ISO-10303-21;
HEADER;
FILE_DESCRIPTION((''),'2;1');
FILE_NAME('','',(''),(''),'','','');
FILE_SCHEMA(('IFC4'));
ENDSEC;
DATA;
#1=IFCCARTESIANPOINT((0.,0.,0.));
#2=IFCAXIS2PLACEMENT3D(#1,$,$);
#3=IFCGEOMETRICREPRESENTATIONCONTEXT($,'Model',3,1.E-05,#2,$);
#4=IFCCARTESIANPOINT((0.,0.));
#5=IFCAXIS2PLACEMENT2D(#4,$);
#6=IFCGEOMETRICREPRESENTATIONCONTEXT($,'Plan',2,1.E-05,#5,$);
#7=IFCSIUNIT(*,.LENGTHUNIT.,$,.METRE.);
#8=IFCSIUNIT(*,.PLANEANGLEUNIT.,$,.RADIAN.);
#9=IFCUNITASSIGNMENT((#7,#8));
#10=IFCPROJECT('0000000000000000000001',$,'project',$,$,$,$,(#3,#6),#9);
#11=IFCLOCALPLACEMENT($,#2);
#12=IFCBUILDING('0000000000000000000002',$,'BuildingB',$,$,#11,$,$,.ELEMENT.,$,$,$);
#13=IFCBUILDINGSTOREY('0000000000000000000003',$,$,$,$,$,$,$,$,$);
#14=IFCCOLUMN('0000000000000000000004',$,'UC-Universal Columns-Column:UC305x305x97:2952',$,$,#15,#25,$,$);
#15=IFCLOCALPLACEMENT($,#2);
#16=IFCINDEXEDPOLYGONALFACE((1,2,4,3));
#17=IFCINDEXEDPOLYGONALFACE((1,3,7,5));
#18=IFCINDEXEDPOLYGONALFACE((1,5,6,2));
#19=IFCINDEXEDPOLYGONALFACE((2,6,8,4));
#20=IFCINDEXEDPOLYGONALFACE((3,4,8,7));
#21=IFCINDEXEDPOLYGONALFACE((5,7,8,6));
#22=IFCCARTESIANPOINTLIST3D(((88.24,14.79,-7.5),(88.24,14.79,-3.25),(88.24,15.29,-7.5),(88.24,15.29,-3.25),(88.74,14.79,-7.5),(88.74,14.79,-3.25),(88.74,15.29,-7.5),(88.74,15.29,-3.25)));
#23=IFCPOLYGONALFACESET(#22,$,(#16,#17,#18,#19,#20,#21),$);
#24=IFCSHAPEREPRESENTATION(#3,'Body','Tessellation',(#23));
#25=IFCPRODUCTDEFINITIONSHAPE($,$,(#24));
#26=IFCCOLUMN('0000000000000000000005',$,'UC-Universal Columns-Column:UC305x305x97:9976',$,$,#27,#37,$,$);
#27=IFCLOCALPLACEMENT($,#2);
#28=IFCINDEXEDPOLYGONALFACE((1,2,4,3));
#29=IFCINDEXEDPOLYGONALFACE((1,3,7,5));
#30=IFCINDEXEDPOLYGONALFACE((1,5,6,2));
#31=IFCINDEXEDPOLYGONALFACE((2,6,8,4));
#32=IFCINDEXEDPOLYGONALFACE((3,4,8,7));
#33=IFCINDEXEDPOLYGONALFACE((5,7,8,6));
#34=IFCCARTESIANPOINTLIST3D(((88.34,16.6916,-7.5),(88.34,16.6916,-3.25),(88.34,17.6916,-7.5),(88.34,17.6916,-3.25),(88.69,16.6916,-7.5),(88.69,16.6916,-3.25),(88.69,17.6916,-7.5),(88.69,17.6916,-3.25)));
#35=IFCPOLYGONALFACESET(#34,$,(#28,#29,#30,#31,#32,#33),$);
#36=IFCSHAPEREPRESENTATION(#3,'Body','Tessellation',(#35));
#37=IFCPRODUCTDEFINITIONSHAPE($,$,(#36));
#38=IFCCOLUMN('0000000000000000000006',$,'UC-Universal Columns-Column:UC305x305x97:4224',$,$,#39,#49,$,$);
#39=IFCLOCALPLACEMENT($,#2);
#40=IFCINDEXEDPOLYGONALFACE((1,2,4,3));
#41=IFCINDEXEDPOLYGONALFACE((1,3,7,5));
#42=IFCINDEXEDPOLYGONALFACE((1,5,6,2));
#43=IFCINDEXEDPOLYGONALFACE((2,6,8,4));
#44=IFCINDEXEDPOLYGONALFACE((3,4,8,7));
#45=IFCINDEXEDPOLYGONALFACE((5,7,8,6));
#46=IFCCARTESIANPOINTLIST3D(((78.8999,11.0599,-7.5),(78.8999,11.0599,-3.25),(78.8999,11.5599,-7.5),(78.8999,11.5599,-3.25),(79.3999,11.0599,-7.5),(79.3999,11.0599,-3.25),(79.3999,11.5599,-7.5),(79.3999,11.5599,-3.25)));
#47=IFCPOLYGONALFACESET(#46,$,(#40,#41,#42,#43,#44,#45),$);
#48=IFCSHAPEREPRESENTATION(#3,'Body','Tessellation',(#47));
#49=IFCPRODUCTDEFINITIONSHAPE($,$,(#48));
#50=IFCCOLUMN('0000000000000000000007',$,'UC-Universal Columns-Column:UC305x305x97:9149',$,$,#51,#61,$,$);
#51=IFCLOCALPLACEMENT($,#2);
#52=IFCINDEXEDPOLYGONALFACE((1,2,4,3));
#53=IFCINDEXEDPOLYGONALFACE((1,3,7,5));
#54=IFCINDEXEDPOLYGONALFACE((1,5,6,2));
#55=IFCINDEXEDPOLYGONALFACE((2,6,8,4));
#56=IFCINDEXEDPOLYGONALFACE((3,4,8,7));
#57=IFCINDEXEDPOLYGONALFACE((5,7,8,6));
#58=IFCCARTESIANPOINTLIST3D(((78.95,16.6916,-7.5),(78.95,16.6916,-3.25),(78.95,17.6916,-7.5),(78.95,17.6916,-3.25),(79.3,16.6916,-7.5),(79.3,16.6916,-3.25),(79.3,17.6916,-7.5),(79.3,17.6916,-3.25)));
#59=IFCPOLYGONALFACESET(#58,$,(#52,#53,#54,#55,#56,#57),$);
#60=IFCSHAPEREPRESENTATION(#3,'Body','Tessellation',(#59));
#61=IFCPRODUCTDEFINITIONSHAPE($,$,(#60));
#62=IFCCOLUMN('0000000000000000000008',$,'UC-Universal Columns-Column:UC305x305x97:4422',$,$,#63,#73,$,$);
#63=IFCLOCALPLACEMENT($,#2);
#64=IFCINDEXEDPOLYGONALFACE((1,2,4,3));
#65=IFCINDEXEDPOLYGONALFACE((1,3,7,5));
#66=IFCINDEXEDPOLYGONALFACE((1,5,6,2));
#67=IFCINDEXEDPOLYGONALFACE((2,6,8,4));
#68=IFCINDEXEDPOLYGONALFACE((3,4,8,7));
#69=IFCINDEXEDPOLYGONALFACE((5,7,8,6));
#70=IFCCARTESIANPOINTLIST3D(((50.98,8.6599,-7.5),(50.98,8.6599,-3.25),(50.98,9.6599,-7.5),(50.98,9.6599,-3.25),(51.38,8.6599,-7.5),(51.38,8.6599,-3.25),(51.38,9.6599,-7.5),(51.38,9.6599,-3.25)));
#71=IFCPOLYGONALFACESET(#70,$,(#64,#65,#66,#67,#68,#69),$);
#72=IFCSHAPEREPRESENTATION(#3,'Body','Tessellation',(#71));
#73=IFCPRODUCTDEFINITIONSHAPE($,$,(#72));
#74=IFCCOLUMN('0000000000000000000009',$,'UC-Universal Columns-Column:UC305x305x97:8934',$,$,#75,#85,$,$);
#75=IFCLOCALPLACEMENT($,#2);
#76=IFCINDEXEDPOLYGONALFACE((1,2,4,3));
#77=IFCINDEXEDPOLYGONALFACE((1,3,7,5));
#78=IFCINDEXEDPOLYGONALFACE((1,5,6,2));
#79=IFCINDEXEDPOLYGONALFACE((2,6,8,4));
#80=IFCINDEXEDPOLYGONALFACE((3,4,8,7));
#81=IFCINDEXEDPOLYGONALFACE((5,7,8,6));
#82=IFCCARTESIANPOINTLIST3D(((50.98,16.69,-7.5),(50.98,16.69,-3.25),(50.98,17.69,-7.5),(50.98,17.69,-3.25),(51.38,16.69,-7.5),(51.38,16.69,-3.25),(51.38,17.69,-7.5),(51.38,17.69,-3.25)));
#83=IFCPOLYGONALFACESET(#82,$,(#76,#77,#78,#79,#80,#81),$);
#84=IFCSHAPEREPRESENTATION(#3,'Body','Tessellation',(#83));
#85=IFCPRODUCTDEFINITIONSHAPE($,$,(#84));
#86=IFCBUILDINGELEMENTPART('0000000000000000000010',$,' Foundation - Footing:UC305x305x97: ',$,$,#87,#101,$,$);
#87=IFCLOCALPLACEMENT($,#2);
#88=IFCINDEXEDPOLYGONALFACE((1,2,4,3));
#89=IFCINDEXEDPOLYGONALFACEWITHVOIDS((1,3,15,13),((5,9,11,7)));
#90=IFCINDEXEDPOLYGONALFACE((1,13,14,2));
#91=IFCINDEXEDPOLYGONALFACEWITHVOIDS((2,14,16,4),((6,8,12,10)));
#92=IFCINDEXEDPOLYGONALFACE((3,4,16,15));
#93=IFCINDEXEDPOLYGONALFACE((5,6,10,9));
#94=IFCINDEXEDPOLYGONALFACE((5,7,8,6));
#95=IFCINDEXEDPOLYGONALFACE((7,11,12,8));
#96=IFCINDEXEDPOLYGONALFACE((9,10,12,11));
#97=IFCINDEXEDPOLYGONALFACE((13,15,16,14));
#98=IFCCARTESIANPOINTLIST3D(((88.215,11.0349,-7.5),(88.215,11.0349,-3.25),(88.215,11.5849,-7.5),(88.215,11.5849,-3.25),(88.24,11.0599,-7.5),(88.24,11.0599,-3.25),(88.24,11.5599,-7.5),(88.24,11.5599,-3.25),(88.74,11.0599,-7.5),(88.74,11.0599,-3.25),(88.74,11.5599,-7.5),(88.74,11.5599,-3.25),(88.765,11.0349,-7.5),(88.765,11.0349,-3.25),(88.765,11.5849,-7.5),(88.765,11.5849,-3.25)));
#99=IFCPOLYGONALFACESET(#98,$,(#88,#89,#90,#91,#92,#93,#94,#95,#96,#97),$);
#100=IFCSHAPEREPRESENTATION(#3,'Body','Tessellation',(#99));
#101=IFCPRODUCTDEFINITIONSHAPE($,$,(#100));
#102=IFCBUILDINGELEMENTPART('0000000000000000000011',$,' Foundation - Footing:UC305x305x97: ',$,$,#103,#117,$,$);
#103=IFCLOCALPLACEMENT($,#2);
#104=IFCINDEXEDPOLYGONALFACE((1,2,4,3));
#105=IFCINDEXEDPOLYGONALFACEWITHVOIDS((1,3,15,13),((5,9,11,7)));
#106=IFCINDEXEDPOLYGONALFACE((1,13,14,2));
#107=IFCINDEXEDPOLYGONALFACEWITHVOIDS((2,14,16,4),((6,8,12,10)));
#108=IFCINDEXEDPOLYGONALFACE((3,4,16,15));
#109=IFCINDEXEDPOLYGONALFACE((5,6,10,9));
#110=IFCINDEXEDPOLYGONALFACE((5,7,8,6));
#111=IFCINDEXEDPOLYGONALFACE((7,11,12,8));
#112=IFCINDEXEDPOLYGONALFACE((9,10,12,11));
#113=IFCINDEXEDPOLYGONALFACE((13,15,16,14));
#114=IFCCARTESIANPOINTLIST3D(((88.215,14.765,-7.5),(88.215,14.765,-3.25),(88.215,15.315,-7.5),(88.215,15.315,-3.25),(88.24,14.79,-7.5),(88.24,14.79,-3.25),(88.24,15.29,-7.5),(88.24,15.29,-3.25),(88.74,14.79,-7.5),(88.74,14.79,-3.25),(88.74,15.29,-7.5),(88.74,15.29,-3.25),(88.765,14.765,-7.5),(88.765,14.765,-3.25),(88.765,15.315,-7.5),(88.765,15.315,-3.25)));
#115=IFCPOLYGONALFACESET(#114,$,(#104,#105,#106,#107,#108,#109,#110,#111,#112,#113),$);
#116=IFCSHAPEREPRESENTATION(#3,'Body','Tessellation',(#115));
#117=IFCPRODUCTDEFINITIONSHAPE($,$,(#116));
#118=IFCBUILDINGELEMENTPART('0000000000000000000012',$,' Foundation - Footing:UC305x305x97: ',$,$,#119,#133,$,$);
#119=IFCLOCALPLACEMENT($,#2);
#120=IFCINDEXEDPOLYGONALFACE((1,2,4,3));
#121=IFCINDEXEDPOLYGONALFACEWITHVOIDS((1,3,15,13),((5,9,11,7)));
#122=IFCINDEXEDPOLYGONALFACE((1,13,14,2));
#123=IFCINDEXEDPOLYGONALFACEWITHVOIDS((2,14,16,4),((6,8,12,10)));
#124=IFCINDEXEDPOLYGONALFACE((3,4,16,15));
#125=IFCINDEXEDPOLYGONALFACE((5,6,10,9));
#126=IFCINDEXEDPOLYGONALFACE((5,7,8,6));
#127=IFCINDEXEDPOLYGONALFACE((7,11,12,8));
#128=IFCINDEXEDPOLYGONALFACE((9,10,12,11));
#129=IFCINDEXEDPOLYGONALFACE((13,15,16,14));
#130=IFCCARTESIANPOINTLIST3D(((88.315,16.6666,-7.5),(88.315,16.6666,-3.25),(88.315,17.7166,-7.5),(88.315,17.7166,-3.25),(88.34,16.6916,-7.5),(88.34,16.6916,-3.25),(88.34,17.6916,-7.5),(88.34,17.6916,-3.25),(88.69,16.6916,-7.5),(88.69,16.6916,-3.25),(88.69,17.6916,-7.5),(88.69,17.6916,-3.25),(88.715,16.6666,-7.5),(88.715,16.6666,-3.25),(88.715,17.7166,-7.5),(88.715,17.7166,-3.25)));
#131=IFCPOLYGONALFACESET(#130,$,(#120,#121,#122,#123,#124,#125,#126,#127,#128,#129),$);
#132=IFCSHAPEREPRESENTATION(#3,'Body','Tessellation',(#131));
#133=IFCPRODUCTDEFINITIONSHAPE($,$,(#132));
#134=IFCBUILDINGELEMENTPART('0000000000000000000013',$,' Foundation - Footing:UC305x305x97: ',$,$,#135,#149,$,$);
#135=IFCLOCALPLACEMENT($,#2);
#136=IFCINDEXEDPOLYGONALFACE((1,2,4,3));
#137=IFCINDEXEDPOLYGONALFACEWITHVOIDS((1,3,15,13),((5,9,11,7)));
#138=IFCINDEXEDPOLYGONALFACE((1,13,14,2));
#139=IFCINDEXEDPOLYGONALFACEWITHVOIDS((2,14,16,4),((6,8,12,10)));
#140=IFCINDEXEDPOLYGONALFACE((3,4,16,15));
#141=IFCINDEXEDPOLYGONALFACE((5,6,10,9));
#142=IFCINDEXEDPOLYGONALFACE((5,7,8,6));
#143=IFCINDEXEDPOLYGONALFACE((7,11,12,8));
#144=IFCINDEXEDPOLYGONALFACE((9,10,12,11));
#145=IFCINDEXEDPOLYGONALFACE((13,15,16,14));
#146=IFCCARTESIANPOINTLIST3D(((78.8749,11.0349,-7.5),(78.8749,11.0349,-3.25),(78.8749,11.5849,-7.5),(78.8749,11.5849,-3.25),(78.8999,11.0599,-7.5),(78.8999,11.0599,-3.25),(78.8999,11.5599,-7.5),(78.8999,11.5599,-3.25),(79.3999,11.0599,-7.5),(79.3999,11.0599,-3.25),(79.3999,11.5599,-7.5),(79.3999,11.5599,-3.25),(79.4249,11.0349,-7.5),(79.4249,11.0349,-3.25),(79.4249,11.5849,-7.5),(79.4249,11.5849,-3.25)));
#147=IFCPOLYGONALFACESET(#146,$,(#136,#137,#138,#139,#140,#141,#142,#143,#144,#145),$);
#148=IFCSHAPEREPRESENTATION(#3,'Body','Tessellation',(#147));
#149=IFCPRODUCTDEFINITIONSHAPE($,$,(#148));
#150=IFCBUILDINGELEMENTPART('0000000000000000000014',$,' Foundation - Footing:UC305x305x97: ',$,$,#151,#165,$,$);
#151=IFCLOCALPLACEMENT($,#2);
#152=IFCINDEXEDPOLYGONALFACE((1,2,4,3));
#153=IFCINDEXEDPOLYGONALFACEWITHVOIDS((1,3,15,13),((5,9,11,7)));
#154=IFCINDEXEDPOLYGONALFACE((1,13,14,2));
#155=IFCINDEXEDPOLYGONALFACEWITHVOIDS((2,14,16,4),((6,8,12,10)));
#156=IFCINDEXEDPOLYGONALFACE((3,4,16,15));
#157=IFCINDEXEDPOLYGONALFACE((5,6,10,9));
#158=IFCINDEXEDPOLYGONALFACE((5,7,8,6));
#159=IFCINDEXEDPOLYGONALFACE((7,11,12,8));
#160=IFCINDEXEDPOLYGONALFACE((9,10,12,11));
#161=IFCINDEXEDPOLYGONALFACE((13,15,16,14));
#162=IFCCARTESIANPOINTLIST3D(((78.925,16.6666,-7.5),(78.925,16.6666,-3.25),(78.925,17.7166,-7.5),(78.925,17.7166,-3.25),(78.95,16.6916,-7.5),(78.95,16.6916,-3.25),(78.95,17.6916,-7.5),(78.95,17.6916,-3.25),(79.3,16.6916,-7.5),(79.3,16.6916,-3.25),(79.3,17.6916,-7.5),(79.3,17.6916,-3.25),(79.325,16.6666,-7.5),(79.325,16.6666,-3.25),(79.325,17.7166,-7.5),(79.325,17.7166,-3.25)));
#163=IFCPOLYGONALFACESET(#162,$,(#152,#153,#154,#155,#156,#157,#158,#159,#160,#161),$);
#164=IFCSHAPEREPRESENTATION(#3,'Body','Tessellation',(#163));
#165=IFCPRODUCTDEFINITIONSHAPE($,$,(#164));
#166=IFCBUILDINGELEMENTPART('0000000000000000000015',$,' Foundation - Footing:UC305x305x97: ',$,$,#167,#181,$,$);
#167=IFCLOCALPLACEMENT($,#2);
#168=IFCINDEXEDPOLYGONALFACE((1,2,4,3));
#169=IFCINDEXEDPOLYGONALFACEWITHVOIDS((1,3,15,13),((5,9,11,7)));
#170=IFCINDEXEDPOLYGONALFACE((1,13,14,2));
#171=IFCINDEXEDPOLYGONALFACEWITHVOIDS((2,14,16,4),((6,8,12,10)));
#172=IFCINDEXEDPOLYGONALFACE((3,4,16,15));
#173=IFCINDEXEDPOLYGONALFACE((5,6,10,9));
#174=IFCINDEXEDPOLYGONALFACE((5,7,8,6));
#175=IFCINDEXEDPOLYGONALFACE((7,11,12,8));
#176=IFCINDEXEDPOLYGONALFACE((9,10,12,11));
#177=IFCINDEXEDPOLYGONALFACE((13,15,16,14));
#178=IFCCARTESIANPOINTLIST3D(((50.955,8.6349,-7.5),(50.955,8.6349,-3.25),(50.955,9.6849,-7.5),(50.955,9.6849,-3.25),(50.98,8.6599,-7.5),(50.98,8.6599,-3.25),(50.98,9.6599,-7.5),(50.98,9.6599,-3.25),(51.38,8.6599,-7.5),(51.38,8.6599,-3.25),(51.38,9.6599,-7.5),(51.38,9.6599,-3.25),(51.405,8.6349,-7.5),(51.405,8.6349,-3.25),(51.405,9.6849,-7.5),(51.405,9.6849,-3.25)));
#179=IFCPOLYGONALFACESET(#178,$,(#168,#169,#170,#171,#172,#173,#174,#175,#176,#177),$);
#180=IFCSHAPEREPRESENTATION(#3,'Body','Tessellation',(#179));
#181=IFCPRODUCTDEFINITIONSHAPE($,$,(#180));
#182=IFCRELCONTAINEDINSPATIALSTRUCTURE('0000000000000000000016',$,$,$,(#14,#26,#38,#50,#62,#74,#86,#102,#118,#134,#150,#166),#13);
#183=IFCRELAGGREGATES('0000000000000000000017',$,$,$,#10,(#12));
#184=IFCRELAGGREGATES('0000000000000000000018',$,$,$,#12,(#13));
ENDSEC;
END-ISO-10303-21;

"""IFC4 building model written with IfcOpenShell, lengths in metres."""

from ifc_helpers import new_model, si_unit, origin, origin_2d, place, context, project, spatial, polyline, outline, extrude, element, save


model = new_model("IFC4")

# Units and contexts
model_context = context("Model", 3, precision=1e-05, world=origin())
plan_context = context("Plan", 2, precision=1e-05, world=origin_2d())
ifc_project = project(units=[si_unit("LENGTHUNIT", "METRE"), si_unit("PLANEANGLEUNIT", "RADIAN")], contexts=[model_context, plan_context])

# Building, storey
building_placement = place(None, origin())
building = spatial("IfcBuilding", under=ifc_project, at=building_placement, Name="BuildingB", CompositionType="ELEMENT")
storey = spatial("IfcBuildingStorey", under=building)

# Columns
element("IfcColumn", 1, inside=storey, Name="UC-Universal Columns-Column:UC305x305x97:2952", context=model_context, shape_type="SweptSolid", body=[
    extrude(outline(polyline([(88.74, 15.29, -7.5), (88.24, 15.29, -7.5), (88.24, 14.79, -7.5), (88.74, 14.79, -7.5), (88.74, 15.29, -7.5)])), None, (0.0, 0.0, 1.0), 4.25),
])
element("IfcColumn", 2, inside=storey, Name="UC-Universal Columns-Column:UC305x305x97:9976", context=model_context, shape_type="SweptSolid", body=[
    extrude(outline(polyline([(88.34, 17.6916, -7.5), (88.69, 17.6916, -7.5), (88.69, 16.6916, -7.5), (88.34, 16.6916, -7.5), (88.34, 17.6916, -7.5)])), None, (0.0, 0.0, 1.0), 4.25),
])
element("IfcColumn", 3, inside=storey, Name="UC-Universal Columns-Column:UC305x305x97:4224", context=model_context, shape_type="SweptSolid", body=[
    extrude(outline(polyline([(78.8999, 11.0599, -7.5), (79.3999, 11.0599, -7.5), (79.3999, 11.5599, -7.5), (78.8999, 11.5599, -7.5), (78.8999, 11.0599, -7.5)])), None, (0.0, 0.0, 1.0), 4.25),
])
element("IfcColumn", 4, inside=storey, Name="UC-Universal Columns-Column:UC305x305x97:9149", context=model_context, shape_type="SweptSolid", body=[
    extrude(outline(polyline([(79.3, 17.6916, -7.5), (78.95, 17.6916, -7.5), (78.95, 16.6916, -7.5), (79.3, 16.6916, -7.5), (79.3, 17.6916, -7.5)])), None, (0.0, 0.0, 1.0), 4.25),
])
element("IfcColumn", 5, inside=storey, Name="UC-Universal Columns-Column:UC305x305x97:4422", context=model_context, shape_type="SweptSolid", body=[
    extrude(outline(polyline([(51.38, 8.6599, -7.5), (50.98, 8.6599, -7.5), (50.98, 9.6599, -7.5), (51.38, 9.6599, -7.5), (51.38, 8.6599, -7.5)])), None, (0.0, 0.0, 1.0), 4.25),
])
element("IfcColumn", 6, inside=storey, Name="UC-Universal Columns-Column:UC305x305x97:8934", context=model_context, shape_type="SweptSolid", body=[
    extrude(outline(polyline([(51.38, 17.69, -7.5), (50.98, 17.69, -7.5), (50.98, 16.69, -7.5), (51.38, 16.69, -7.5), (51.38, 17.69, -7.5)])), None, (0.0, 0.0, 1.0), 4.25),
])

# Building element parts, openings
building_element_part_1 = element("IfcBuildingElementPart", 7, inside=storey, Name=" Foundation - Footing:UC305x305x97: ", context=model_context, shape_type="SweptSolid", body=[
    extrude(outline(polyline([(88.765, 11.0349, -7.5), (88.215, 11.0349, -7.5), (88.215, 11.5849, -7.5), (88.765, 11.5849, -7.5), (88.765, 11.0349, -7.5)])), None, (0.0, 0.0, 1.0), 4.25),
])
element("IfcOpeningElement", 8, inside=storey, cuts=building_element_part_1, context=model_context, shape_type="SweptSolid", body=[
    extrude(outline(polyline([(88.74, 11.0599, -7.5), (88.24, 11.0599, -7.5), (88.24, 11.5599, -7.5), (88.74, 11.5599, -7.5), (88.74, 11.0599, -7.5)])), None, (0.0, 0.0, 1.0), 4.25),
])
building_element_part_2 = element("IfcBuildingElementPart", 9, inside=storey, Name=" Foundation - Footing:UC305x305x97: ", context=model_context, shape_type="SweptSolid", body=[
    extrude(outline(polyline([(88.765, 15.315, -7.5), (88.215, 15.315, -7.5), (88.215, 14.765, -7.5), (88.765, 14.765, -7.5), (88.765, 15.315, -7.5)])), None, (0.0, 0.0, 1.0), 4.25),
])
element("IfcOpeningElement", 10, inside=storey, cuts=building_element_part_2, context=model_context, shape_type="SweptSolid", body=[
    extrude(outline(polyline([(88.74, 15.29, -7.5), (88.24, 15.29, -7.5), (88.24, 14.79, -7.5), (88.74, 14.79, -7.5), (88.74, 15.29, -7.5)])), None, (0.0, 0.0, 1.0), 4.25),
])
building_element_part_3 = element("IfcBuildingElementPart", 11, inside=storey, Name=" Foundation - Footing:UC305x305x97: ", context=model_context, shape_type="SweptSolid", body=[
    extrude(outline(polyline([(88.315, 17.7166, -7.5), (88.715, 17.7166, -7.5), (88.715, 16.6666, -7.5), (88.315, 16.6666, -7.5), (88.315, 17.7166, -7.5)])), None, (0.0, 0.0, 1.0), 4.25),
])
element("IfcOpeningElement", 12, inside=storey, cuts=building_element_part_3, context=model_context, shape_type="SweptSolid", body=[
    extrude(outline(polyline([(88.34, 17.6916, -7.5), (88.69, 17.6916, -7.5), (88.69, 16.6916, -7.5), (88.34, 16.6916, -7.5), (88.34, 17.6916, -7.5)])), None, (0.0, 0.0, 1.0), 4.25),
])
building_element_part_4 = element("IfcBuildingElementPart", 13, inside=storey, Name=" Foundation - Footing:UC305x305x97: ", context=model_context, shape_type="SweptSolid", body=[
    extrude(outline(polyline([(78.8749, 11.0349, -7.5), (79.4249, 11.0349, -7.5), (79.4249, 11.5849, -7.5), (78.8749, 11.5849, -7.5), (78.8749, 11.0349, -7.5)])), None, (0.0, 0.0, 1.0), 4.25),
])
element("IfcOpeningElement", 14, inside=storey, cuts=building_element_part_4, context=model_context, shape_type="SweptSolid", body=[
    extrude(outline(polyline([(78.8999, 11.0599, -7.5), (79.3999, 11.0599, -7.5), (79.3999, 11.5599, -7.5), (78.8999, 11.5599, -7.5), (78.8999, 11.0599, -7.5)])), None, (0.0, 0.0, 1.0), 4.25),
])
building_element_part_5 = element("IfcBuildingElementPart", 15, inside=storey, Name=" Foundation - Footing:UC305x305x97: ", context=model_context, shape_type="SweptSolid", body=[
    extrude(outline(polyline([(79.325, 17.7166, -7.5), (78.925, 17.7166, -7.5), (78.925, 16.6666, -7.5), (79.325, 16.6666, -7.5), (79.325, 17.7166, -7.5)])), None, (0.0, 0.0, 1.0), 4.25),
])
element("IfcOpeningElement", 16, inside=storey, cuts=building_element_part_5, context=model_context, shape_type="SweptSolid", body=[
    extrude(outline(polyline([(79.3, 17.6916, -7.5), (78.95, 17.6916, -7.5), (78.95, 16.6916, -7.5), (79.3, 16.6916, -7.5), (79.3, 17.6916, -7.5)])), None, (0.0, 0.0, 1.0), 4.25),
])
building_element_part_6 = element("IfcBuildingElementPart", 17, inside=storey, Name=" Foundation - Footing:UC305x305x97: ", context=model_context, shape_type="SweptSolid", body=[
    extrude(outline(polyline([(51.405, 8.6349, -7.5), (50.955, 8.6349, -7.5), (50.955, 9.6849, -7.5), (51.405, 9.6849, -7.5), (51.405, 8.6349, -7.5)])), None, (0.0, 0.0, 1.0), 4.25),
])
element("IfcOpeningElement", 18, inside=storey, cuts=building_element_part_6, context=model_context, shape_type="SweptSolid", body=[
    extrude(outline(polyline([(51.38, 8.6599, -7.5), (50.98, 8.6599, -7.5), (50.98, 9.6599, -7.5), (51.38, 9.6599, -7.5), (51.38, 8.6599, -7.5)])), None, (0.0, 0.0, 1.0), 4.25),
])

save(model, "model.ifc")
